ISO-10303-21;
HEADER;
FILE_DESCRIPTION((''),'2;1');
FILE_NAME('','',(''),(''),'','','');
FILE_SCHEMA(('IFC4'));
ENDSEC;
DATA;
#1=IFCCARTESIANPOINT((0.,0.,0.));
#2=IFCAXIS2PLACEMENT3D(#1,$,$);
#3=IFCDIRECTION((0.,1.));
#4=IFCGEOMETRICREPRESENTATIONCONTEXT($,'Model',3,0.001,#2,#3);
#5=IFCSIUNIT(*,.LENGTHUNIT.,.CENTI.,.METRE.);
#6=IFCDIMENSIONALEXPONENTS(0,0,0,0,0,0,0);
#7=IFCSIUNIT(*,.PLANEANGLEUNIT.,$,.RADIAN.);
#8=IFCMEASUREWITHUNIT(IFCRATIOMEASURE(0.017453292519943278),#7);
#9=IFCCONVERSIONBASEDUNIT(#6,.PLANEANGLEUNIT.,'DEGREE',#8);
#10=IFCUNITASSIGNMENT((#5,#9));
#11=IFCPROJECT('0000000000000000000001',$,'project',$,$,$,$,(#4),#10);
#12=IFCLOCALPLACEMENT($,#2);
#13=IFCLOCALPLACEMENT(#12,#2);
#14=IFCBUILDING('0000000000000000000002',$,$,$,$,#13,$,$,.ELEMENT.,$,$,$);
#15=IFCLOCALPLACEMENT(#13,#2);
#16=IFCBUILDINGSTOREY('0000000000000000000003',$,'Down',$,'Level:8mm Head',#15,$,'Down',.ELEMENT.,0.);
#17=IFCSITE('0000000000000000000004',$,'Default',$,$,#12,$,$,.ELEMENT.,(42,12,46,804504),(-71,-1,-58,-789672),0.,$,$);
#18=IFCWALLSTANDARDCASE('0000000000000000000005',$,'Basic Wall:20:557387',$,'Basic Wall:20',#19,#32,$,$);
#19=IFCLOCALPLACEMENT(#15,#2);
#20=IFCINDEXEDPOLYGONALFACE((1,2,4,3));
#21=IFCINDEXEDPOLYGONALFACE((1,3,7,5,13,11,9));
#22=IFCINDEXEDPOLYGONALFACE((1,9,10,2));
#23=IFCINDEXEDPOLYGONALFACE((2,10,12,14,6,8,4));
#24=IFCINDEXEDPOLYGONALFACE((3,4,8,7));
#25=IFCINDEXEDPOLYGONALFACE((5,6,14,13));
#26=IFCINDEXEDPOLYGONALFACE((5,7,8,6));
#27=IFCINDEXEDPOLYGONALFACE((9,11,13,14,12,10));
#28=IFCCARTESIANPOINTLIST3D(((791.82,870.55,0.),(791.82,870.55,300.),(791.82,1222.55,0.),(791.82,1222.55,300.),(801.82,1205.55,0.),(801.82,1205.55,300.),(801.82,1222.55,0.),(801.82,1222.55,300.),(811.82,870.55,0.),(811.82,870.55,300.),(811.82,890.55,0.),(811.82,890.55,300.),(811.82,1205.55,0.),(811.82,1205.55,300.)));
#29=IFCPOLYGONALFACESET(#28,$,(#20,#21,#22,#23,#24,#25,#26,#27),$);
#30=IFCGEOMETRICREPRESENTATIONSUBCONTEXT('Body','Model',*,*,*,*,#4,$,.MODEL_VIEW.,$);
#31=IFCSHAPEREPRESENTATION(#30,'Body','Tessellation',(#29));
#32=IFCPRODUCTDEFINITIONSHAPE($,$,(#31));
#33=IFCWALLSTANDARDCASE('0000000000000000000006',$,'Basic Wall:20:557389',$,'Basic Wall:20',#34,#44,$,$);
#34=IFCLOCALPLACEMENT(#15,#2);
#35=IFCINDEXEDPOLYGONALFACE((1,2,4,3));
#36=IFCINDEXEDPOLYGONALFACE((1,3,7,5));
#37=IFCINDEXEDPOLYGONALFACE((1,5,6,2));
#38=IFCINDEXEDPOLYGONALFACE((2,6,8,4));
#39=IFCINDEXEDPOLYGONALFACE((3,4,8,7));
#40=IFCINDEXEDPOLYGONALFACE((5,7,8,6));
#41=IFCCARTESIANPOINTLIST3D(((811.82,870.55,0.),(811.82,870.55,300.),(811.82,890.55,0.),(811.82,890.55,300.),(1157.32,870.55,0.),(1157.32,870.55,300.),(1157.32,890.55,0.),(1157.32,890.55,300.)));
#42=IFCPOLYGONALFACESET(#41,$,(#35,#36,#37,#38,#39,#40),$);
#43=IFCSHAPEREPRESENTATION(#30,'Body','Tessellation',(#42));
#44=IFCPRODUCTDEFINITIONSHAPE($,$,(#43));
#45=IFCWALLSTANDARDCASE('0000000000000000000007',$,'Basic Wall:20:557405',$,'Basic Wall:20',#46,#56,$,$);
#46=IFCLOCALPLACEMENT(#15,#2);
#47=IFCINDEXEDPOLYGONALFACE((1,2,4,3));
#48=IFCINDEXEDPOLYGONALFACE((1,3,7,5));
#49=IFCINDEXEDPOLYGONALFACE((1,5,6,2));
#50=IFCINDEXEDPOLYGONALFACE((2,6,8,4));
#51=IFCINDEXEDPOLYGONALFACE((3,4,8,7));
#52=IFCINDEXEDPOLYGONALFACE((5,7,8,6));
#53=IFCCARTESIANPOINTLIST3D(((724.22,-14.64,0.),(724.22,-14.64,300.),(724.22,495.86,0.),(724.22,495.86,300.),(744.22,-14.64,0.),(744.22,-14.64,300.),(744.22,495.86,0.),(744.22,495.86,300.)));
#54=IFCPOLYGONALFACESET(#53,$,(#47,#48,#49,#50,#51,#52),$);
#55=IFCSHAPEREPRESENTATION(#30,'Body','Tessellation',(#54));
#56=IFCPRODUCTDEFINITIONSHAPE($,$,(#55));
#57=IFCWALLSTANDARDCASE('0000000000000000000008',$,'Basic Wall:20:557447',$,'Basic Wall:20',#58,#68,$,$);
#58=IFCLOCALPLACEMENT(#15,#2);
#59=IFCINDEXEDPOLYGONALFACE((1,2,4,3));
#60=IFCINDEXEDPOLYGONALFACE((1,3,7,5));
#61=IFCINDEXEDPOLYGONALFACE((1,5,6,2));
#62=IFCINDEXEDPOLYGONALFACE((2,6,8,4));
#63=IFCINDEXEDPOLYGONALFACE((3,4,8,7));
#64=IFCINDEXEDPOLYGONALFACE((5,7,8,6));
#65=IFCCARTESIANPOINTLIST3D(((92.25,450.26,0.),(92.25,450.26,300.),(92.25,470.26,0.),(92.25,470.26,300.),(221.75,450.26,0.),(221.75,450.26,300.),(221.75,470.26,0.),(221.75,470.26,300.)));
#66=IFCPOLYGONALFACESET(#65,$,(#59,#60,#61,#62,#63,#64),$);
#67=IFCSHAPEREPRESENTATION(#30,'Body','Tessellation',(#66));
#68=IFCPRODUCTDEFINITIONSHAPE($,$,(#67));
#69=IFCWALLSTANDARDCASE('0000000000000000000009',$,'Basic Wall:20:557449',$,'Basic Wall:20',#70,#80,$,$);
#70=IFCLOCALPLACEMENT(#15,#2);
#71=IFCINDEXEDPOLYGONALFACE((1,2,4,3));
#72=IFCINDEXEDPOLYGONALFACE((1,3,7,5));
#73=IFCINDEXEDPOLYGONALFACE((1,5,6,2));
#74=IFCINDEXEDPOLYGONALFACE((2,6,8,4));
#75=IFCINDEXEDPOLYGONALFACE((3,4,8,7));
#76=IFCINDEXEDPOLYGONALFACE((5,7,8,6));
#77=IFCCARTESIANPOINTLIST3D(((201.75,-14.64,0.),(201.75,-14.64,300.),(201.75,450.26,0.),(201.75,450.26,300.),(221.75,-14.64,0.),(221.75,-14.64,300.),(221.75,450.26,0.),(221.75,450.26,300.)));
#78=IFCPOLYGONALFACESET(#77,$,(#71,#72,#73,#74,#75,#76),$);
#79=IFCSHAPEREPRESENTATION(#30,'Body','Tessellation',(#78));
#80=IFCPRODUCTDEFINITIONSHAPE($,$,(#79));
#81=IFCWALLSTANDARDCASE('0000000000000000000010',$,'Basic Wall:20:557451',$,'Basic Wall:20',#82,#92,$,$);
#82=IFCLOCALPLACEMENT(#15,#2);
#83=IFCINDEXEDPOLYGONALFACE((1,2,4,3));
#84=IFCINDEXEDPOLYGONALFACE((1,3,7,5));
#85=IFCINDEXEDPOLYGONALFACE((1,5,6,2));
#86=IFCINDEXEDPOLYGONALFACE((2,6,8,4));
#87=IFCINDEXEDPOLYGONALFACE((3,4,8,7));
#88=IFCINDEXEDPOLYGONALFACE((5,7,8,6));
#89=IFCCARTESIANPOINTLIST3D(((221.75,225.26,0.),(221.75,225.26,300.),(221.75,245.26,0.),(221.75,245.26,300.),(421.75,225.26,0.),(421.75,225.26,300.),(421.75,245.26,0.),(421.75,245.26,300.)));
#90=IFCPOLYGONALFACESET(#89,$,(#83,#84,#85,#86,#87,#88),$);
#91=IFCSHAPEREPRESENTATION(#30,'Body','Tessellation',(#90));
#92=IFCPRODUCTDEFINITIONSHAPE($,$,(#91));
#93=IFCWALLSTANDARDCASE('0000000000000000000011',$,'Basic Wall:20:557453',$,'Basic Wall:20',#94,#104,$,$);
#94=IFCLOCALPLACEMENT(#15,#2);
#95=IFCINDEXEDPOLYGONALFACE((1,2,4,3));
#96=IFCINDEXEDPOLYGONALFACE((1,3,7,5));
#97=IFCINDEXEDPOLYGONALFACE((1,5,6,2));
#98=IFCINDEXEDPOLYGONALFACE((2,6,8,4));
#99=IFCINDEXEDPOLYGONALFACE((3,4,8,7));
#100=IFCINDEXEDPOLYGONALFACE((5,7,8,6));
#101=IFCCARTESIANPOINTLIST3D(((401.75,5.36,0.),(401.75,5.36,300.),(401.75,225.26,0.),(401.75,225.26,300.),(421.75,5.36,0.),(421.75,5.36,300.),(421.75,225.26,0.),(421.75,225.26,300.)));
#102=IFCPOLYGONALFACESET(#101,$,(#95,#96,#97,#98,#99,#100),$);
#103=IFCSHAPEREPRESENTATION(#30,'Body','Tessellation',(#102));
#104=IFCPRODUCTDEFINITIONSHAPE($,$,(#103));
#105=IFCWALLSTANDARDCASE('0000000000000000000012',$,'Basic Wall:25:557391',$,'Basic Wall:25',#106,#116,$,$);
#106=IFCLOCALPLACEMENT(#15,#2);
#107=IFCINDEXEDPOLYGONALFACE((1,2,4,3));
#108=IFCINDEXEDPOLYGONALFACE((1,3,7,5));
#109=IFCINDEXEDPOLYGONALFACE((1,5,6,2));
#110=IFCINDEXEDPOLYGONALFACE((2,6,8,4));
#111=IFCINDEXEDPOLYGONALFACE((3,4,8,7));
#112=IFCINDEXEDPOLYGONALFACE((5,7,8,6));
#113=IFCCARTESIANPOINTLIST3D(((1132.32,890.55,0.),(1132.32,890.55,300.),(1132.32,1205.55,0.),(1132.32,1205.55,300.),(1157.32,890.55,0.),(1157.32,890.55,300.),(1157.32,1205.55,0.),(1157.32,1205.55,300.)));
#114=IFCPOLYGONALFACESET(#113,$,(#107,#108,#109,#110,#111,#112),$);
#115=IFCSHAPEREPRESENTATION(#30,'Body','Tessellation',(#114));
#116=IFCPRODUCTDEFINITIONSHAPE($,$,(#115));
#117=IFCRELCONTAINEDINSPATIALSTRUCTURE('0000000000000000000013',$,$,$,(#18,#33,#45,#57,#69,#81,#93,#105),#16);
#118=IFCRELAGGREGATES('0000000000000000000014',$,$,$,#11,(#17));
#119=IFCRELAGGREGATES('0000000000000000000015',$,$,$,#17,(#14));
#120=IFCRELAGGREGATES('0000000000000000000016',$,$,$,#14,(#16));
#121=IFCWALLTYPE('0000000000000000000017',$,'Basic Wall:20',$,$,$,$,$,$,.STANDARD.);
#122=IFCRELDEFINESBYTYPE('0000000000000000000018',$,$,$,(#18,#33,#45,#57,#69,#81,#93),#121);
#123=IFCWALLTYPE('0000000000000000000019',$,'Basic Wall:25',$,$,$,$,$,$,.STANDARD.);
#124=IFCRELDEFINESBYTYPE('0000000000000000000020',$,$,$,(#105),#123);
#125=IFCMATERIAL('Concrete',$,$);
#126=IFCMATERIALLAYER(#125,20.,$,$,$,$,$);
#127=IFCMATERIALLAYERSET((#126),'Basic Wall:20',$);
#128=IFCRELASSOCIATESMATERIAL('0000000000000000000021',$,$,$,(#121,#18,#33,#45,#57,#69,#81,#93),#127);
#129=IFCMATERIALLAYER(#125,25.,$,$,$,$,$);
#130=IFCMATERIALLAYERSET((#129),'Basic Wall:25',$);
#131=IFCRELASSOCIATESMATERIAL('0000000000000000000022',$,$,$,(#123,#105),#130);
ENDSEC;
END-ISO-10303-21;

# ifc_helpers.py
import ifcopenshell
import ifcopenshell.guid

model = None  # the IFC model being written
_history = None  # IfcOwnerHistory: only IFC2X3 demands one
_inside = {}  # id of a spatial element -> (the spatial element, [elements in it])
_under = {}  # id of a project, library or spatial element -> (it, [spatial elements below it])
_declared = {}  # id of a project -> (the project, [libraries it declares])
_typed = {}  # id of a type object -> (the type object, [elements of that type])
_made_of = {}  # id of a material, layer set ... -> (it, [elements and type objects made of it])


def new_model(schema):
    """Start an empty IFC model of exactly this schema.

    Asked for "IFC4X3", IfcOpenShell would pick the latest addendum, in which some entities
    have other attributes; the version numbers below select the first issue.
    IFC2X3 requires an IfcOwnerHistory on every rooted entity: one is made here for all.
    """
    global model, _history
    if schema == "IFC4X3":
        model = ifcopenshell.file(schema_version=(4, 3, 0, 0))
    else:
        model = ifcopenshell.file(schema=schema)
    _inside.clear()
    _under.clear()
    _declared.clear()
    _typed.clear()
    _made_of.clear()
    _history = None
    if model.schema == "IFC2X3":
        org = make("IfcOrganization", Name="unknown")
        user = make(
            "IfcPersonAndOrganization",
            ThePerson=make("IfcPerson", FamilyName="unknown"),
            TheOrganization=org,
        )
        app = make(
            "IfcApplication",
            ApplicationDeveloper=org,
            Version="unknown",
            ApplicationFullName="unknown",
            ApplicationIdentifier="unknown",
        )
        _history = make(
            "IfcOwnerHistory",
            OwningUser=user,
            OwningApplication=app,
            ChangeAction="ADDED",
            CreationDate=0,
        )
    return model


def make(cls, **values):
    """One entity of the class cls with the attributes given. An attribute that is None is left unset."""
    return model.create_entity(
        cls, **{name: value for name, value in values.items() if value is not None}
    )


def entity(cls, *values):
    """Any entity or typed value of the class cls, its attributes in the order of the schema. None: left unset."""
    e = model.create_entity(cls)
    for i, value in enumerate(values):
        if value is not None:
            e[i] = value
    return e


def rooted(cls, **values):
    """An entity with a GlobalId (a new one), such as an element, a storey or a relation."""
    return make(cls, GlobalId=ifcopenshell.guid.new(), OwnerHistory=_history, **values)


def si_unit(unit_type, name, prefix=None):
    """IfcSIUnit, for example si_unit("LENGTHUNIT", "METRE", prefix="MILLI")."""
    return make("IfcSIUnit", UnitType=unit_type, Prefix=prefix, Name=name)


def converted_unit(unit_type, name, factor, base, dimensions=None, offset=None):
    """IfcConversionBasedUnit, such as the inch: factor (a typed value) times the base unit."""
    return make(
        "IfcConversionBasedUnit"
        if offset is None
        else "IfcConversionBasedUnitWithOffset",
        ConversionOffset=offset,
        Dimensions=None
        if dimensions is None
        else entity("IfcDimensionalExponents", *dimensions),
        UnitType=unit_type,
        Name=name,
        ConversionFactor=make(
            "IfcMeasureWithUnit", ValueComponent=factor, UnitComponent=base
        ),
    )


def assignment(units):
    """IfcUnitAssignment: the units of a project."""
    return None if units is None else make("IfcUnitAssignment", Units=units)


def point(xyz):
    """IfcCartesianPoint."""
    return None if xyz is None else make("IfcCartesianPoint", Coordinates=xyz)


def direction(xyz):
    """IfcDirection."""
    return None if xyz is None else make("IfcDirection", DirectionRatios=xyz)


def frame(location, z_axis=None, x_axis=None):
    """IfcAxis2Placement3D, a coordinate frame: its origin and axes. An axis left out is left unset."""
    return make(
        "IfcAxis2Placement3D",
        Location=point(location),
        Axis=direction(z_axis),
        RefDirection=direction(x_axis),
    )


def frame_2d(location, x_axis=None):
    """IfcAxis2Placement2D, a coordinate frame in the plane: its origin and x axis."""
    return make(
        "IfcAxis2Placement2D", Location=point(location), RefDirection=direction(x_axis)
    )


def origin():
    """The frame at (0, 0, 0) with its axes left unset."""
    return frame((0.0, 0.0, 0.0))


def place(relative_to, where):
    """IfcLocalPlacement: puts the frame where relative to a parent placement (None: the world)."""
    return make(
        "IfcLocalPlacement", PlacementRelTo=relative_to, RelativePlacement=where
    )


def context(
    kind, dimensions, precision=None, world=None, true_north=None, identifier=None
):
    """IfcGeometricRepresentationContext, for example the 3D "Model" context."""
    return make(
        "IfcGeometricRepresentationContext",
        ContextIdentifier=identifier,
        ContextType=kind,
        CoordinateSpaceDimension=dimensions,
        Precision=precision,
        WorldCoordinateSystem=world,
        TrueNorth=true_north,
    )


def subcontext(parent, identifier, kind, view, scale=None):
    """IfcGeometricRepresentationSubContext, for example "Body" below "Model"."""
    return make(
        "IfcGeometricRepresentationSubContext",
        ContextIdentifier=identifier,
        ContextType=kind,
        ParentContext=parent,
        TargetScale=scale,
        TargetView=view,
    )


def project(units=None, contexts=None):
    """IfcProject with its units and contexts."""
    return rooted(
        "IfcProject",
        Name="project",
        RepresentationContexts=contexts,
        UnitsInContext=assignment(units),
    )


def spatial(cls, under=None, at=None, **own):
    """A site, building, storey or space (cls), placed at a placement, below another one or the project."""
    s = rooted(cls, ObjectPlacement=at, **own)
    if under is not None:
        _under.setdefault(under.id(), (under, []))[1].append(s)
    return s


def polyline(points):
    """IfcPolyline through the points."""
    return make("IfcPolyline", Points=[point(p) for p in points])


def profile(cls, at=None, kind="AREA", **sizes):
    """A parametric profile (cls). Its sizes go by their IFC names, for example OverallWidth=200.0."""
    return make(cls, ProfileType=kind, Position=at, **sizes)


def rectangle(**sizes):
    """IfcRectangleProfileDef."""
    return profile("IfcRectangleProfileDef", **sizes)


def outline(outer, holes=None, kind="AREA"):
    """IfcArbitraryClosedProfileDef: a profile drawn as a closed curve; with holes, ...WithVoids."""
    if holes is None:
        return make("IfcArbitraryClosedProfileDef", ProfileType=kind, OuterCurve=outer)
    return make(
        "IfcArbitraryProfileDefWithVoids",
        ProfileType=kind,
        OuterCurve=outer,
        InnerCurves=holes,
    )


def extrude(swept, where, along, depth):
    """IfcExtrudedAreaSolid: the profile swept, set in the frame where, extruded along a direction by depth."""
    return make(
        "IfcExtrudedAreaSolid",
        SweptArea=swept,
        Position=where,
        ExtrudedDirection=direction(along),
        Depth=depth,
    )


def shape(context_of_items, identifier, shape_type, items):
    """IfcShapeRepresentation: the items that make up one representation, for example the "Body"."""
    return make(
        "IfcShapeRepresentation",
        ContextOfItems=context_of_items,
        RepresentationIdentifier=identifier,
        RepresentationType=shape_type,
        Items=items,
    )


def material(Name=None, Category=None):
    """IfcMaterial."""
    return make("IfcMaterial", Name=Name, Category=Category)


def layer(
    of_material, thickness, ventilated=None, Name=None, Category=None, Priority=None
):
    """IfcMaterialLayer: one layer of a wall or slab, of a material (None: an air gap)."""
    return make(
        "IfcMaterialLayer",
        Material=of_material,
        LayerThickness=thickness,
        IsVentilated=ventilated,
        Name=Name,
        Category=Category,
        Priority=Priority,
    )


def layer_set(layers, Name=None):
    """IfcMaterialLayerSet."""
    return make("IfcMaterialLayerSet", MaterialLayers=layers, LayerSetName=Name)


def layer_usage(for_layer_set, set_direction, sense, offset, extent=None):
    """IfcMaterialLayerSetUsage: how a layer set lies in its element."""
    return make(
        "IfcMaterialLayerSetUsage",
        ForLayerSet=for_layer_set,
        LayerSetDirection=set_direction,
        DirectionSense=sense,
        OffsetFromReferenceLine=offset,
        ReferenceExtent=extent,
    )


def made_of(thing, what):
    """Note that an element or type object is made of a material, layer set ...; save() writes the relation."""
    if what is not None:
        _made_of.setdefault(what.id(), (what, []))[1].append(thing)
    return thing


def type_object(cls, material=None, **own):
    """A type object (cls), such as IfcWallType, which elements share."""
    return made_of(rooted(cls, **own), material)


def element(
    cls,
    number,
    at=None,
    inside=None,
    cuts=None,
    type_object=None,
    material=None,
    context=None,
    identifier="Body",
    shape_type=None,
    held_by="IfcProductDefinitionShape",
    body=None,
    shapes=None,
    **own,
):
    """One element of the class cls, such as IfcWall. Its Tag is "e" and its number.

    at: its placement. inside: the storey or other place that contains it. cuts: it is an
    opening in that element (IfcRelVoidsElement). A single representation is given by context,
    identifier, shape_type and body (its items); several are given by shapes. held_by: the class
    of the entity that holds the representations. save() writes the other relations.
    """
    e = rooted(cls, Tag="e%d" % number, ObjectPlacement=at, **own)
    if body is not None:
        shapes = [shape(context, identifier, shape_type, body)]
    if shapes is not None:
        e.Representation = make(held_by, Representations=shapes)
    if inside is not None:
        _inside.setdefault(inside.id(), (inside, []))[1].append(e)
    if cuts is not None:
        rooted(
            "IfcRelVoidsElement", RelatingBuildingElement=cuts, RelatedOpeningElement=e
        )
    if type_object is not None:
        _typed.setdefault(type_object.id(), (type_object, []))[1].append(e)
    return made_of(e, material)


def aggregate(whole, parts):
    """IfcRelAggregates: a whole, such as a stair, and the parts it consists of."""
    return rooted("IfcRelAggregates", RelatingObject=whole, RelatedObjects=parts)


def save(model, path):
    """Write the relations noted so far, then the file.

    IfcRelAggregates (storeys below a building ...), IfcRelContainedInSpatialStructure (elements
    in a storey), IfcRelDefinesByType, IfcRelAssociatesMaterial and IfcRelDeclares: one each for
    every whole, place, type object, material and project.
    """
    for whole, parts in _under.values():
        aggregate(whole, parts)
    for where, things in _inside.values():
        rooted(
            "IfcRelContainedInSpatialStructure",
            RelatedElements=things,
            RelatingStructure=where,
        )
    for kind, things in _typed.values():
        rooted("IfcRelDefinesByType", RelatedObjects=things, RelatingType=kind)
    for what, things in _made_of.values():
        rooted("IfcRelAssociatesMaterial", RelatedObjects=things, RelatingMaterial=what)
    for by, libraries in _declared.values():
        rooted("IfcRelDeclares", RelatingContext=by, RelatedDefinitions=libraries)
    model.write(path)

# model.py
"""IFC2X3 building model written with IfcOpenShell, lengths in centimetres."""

from ifc_helpers import new_model, entity, si_unit, converted_unit, direction, frame, frame_2d, origin, place, context, subcontext, project, spatial, polyline, rectangle, outline, extrude, material, layer, layer_set, layer_usage, type_object, element, save


model = new_model("IFC2X3")

# Units and contexts
model_context = context("Model", 3, precision=0.001, world=origin(), true_north=direction((0.0, 1.0)))
body_context = subcontext(model_context, "Body", "Model", "MODEL_VIEW")
ifc_project = project(units=[si_unit("LENGTHUNIT", "METRE", prefix="CENTI"), converted_unit("PLANEANGLEUNIT", "DEGREE", entity("IfcRatioMeasure", 0.017453292519943278), si_unit("PLANEANGLEUNIT", "RADIAN"), dimensions=[0, 0, 0, 0, 0, 0, 0])], contexts=[model_context])

# Site, building, storey
site_placement = place(None, origin())
site = spatial("IfcSite", under=ifc_project, at=site_placement, Name="Default", CompositionType="ELEMENT", RefLatitude=(42, 12, 46, 804504), RefLongitude=(-71, -1, -58, -789672), RefElevation=0.0)
building_placement = place(site_placement, origin())
building = spatial("IfcBuilding", under=site, at=building_placement, CompositionType="ELEMENT")
storey_placement = place(building_placement, origin())
storey = spatial("IfcBuildingStorey", under=building, at=storey_placement, Name="Down", ObjectType="Level:8mm Head", LongName="Down", CompositionType="ELEMENT", Elevation=0.0)

# Shared definitions
ifc_material = material(Name="Concrete")

# Walls
ifc_layer_1 = layer(ifc_material, 20.0)
ifc_layer_set_1 = layer_set([ifc_layer_1], Name="Basic Wall:20")
wall_type_1 = type_object("IfcWallType", Name="Basic Wall:20", PredefinedType="STANDARD", material=ifc_layer_set_1)
ifc_layer_usage_1 = layer_usage(ifc_layer_set_1, "AXIS2", "POSITIVE", -10.0)
wall_1_placement = place(storey_placement, frame((801.82, 1222.55, 0.0), z_axis=(0.0, 0.0, 1.0), x_axis=(0.0, -1.0, 0.0)))
element("IfcWallStandardCase", 1, at=wall_1_placement, inside=storey, type_object=wall_type_1, material=ifc_layer_usage_1, Name="Basic Wall:20:557387", ObjectType="Basic Wall:20", context=body_context, shape_type="SweptSolid", body=[
    extrude(outline(polyline([(352.0, -10.0), (352.0, 10.0), (332.0, 10.0), (17.0, 10.0), (17.0, 0.0), (0.0, 0.0), (0.0, -10.0), (352.0, -10.0)])), origin(), (0.0, 0.0, 1.0), 300.0),
])
ifc_layer_usage_2 = layer_usage(ifc_layer_set_1, "AXIS2", "POSITIVE", -10.0)
wall_2_placement = place(storey_placement, frame((811.82, 880.55, 0.0)))
element("IfcWallStandardCase", 2, at=wall_2_placement, inside=storey, type_object=wall_type_1, material=ifc_layer_usage_2, Name="Basic Wall:20:557389", ObjectType="Basic Wall:20", context=body_context, shape_type="SweptSolid", body=[
    extrude(rectangle(XDim=345.5, YDim=20.0, at=frame_2d((172.75, 0.0), x_axis=(-1.0, 0.0))), origin(), (0.0, 0.0, 1.0), 300.0),
])
ifc_layer_usage_3 = layer_usage(ifc_layer_set_1, "AXIS2", "POSITIVE", -10.0)
wall_3_placement = place(storey_placement, frame((734.22, 495.86, 0.0), z_axis=(0.0, 0.0, 1.0), x_axis=(0.0, -1.0, 0.0)))
element("IfcWallStandardCase", 3, at=wall_3_placement, inside=storey, type_object=wall_type_1, material=ifc_layer_usage_3, Name="Basic Wall:20:557405", ObjectType="Basic Wall:20", context=body_context, shape_type="SweptSolid", body=[
    extrude(rectangle(XDim=510.5, YDim=20.0, at=frame_2d((255.25, 0.0), x_axis=(-1.0, 0.0))), origin(), (0.0, 0.0, 1.0), 300.0),
])
ifc_layer_usage_4 = layer_usage(ifc_layer_set_1, "AXIS2", "POSITIVE", -10.0)
wall_4_placement = place(storey_placement, frame((92.25, 460.26, 0.0)))
element("IfcWallStandardCase", 4, at=wall_4_placement, inside=storey, type_object=wall_type_1, material=ifc_layer_usage_4, Name="Basic Wall:20:557447", ObjectType="Basic Wall:20", context=body_context, shape_type="SweptSolid", body=[
    extrude(rectangle(XDim=129.5, YDim=20.0, at=frame_2d((64.75, 0.0), x_axis=(-1.0, 0.0))), origin(), (0.0, 0.0, 1.0), 300.0),
])
ifc_layer_usage_5 = layer_usage(ifc_layer_set_1, "AXIS2", "NEGATIVE", 10.0)
wall_5_placement = place(storey_placement, frame((211.75, 450.26, 0.0), z_axis=(0.0, 0.0, 1.0), x_axis=(0.0, -1.0, 0.0)))
element("IfcWallStandardCase", 5, at=wall_5_placement, inside=storey, type_object=wall_type_1, material=ifc_layer_usage_5, Name="Basic Wall:20:557449", ObjectType="Basic Wall:20", context=body_context, shape_type="SweptSolid", body=[
    extrude(rectangle(XDim=464.9, YDim=20.0, at=frame_2d((232.45, 0.0), x_axis=(-1.0, 0.0))), origin(), (0.0, 0.0, 1.0), 300.0),
])
ifc_layer_usage_6 = layer_usage(ifc_layer_set_1, "AXIS2", "NEGATIVE", 10.0)
wall_6_placement = place(storey_placement, frame((221.75, 235.26, 0.0)))
element("IfcWallStandardCase", 6, at=wall_6_placement, inside=storey, type_object=wall_type_1, material=ifc_layer_usage_6, Name="Basic Wall:20:557451", ObjectType="Basic Wall:20", context=body_context, shape_type="SweptSolid", body=[
    extrude(rectangle(XDim=200.0, YDim=20.0, at=frame_2d((100.0, 0.0), x_axis=(-1.0, 0.0))), origin(), (0.0, 0.0, 1.0), 300.0),
])
ifc_layer_usage_7 = layer_usage(ifc_layer_set_1, "AXIS2", "NEGATIVE", 10.0)
wall_7_placement = place(storey_placement, frame((411.75, 225.26, 0.0), z_axis=(0.0, 0.0, 1.0), x_axis=(0.0, -1.0, 0.0)))
element("IfcWallStandardCase", 7, at=wall_7_placement, inside=storey, type_object=wall_type_1, material=ifc_layer_usage_7, Name="Basic Wall:20:557453", ObjectType="Basic Wall:20", context=body_context, shape_type="SweptSolid", body=[
    extrude(rectangle(XDim=219.9, YDim=20.0, at=frame_2d((109.95, 0.0), x_axis=(-1.0, 0.0))), origin(), (0.0, 0.0, 1.0), 300.0),
])
ifc_layer_2 = layer(ifc_material, 25.0)
ifc_layer_set_2 = layer_set([ifc_layer_2], Name="Basic Wall:25")
ifc_layer_usage_8 = layer_usage(ifc_layer_set_2, "AXIS2", "NEGATIVE", 12.5)
wall_type_2 = type_object("IfcWallType", Name="Basic Wall:25", PredefinedType="STANDARD", material=ifc_layer_set_2)
wall_8_placement = place(storey_placement, frame((1144.82, 1205.55, 0.0), z_axis=(0.0, 0.0, 1.0), x_axis=(0.0, -1.0, 0.0)))
element("IfcWallStandardCase", 8, at=wall_8_placement, inside=storey, type_object=wall_type_2, material=ifc_layer_usage_8, Name="Basic Wall:25:557391", ObjectType="Basic Wall:25", context=body_context, shape_type="SweptSolid", body=[
    extrude(rectangle(XDim=315.0, YDim=25.0, at=frame_2d((157.5, 0.0), x_axis=(-1.0, 0.0))), origin(), (0.0, 0.0, 1.0), 300.0),
])

save(model, "model.ifc")
